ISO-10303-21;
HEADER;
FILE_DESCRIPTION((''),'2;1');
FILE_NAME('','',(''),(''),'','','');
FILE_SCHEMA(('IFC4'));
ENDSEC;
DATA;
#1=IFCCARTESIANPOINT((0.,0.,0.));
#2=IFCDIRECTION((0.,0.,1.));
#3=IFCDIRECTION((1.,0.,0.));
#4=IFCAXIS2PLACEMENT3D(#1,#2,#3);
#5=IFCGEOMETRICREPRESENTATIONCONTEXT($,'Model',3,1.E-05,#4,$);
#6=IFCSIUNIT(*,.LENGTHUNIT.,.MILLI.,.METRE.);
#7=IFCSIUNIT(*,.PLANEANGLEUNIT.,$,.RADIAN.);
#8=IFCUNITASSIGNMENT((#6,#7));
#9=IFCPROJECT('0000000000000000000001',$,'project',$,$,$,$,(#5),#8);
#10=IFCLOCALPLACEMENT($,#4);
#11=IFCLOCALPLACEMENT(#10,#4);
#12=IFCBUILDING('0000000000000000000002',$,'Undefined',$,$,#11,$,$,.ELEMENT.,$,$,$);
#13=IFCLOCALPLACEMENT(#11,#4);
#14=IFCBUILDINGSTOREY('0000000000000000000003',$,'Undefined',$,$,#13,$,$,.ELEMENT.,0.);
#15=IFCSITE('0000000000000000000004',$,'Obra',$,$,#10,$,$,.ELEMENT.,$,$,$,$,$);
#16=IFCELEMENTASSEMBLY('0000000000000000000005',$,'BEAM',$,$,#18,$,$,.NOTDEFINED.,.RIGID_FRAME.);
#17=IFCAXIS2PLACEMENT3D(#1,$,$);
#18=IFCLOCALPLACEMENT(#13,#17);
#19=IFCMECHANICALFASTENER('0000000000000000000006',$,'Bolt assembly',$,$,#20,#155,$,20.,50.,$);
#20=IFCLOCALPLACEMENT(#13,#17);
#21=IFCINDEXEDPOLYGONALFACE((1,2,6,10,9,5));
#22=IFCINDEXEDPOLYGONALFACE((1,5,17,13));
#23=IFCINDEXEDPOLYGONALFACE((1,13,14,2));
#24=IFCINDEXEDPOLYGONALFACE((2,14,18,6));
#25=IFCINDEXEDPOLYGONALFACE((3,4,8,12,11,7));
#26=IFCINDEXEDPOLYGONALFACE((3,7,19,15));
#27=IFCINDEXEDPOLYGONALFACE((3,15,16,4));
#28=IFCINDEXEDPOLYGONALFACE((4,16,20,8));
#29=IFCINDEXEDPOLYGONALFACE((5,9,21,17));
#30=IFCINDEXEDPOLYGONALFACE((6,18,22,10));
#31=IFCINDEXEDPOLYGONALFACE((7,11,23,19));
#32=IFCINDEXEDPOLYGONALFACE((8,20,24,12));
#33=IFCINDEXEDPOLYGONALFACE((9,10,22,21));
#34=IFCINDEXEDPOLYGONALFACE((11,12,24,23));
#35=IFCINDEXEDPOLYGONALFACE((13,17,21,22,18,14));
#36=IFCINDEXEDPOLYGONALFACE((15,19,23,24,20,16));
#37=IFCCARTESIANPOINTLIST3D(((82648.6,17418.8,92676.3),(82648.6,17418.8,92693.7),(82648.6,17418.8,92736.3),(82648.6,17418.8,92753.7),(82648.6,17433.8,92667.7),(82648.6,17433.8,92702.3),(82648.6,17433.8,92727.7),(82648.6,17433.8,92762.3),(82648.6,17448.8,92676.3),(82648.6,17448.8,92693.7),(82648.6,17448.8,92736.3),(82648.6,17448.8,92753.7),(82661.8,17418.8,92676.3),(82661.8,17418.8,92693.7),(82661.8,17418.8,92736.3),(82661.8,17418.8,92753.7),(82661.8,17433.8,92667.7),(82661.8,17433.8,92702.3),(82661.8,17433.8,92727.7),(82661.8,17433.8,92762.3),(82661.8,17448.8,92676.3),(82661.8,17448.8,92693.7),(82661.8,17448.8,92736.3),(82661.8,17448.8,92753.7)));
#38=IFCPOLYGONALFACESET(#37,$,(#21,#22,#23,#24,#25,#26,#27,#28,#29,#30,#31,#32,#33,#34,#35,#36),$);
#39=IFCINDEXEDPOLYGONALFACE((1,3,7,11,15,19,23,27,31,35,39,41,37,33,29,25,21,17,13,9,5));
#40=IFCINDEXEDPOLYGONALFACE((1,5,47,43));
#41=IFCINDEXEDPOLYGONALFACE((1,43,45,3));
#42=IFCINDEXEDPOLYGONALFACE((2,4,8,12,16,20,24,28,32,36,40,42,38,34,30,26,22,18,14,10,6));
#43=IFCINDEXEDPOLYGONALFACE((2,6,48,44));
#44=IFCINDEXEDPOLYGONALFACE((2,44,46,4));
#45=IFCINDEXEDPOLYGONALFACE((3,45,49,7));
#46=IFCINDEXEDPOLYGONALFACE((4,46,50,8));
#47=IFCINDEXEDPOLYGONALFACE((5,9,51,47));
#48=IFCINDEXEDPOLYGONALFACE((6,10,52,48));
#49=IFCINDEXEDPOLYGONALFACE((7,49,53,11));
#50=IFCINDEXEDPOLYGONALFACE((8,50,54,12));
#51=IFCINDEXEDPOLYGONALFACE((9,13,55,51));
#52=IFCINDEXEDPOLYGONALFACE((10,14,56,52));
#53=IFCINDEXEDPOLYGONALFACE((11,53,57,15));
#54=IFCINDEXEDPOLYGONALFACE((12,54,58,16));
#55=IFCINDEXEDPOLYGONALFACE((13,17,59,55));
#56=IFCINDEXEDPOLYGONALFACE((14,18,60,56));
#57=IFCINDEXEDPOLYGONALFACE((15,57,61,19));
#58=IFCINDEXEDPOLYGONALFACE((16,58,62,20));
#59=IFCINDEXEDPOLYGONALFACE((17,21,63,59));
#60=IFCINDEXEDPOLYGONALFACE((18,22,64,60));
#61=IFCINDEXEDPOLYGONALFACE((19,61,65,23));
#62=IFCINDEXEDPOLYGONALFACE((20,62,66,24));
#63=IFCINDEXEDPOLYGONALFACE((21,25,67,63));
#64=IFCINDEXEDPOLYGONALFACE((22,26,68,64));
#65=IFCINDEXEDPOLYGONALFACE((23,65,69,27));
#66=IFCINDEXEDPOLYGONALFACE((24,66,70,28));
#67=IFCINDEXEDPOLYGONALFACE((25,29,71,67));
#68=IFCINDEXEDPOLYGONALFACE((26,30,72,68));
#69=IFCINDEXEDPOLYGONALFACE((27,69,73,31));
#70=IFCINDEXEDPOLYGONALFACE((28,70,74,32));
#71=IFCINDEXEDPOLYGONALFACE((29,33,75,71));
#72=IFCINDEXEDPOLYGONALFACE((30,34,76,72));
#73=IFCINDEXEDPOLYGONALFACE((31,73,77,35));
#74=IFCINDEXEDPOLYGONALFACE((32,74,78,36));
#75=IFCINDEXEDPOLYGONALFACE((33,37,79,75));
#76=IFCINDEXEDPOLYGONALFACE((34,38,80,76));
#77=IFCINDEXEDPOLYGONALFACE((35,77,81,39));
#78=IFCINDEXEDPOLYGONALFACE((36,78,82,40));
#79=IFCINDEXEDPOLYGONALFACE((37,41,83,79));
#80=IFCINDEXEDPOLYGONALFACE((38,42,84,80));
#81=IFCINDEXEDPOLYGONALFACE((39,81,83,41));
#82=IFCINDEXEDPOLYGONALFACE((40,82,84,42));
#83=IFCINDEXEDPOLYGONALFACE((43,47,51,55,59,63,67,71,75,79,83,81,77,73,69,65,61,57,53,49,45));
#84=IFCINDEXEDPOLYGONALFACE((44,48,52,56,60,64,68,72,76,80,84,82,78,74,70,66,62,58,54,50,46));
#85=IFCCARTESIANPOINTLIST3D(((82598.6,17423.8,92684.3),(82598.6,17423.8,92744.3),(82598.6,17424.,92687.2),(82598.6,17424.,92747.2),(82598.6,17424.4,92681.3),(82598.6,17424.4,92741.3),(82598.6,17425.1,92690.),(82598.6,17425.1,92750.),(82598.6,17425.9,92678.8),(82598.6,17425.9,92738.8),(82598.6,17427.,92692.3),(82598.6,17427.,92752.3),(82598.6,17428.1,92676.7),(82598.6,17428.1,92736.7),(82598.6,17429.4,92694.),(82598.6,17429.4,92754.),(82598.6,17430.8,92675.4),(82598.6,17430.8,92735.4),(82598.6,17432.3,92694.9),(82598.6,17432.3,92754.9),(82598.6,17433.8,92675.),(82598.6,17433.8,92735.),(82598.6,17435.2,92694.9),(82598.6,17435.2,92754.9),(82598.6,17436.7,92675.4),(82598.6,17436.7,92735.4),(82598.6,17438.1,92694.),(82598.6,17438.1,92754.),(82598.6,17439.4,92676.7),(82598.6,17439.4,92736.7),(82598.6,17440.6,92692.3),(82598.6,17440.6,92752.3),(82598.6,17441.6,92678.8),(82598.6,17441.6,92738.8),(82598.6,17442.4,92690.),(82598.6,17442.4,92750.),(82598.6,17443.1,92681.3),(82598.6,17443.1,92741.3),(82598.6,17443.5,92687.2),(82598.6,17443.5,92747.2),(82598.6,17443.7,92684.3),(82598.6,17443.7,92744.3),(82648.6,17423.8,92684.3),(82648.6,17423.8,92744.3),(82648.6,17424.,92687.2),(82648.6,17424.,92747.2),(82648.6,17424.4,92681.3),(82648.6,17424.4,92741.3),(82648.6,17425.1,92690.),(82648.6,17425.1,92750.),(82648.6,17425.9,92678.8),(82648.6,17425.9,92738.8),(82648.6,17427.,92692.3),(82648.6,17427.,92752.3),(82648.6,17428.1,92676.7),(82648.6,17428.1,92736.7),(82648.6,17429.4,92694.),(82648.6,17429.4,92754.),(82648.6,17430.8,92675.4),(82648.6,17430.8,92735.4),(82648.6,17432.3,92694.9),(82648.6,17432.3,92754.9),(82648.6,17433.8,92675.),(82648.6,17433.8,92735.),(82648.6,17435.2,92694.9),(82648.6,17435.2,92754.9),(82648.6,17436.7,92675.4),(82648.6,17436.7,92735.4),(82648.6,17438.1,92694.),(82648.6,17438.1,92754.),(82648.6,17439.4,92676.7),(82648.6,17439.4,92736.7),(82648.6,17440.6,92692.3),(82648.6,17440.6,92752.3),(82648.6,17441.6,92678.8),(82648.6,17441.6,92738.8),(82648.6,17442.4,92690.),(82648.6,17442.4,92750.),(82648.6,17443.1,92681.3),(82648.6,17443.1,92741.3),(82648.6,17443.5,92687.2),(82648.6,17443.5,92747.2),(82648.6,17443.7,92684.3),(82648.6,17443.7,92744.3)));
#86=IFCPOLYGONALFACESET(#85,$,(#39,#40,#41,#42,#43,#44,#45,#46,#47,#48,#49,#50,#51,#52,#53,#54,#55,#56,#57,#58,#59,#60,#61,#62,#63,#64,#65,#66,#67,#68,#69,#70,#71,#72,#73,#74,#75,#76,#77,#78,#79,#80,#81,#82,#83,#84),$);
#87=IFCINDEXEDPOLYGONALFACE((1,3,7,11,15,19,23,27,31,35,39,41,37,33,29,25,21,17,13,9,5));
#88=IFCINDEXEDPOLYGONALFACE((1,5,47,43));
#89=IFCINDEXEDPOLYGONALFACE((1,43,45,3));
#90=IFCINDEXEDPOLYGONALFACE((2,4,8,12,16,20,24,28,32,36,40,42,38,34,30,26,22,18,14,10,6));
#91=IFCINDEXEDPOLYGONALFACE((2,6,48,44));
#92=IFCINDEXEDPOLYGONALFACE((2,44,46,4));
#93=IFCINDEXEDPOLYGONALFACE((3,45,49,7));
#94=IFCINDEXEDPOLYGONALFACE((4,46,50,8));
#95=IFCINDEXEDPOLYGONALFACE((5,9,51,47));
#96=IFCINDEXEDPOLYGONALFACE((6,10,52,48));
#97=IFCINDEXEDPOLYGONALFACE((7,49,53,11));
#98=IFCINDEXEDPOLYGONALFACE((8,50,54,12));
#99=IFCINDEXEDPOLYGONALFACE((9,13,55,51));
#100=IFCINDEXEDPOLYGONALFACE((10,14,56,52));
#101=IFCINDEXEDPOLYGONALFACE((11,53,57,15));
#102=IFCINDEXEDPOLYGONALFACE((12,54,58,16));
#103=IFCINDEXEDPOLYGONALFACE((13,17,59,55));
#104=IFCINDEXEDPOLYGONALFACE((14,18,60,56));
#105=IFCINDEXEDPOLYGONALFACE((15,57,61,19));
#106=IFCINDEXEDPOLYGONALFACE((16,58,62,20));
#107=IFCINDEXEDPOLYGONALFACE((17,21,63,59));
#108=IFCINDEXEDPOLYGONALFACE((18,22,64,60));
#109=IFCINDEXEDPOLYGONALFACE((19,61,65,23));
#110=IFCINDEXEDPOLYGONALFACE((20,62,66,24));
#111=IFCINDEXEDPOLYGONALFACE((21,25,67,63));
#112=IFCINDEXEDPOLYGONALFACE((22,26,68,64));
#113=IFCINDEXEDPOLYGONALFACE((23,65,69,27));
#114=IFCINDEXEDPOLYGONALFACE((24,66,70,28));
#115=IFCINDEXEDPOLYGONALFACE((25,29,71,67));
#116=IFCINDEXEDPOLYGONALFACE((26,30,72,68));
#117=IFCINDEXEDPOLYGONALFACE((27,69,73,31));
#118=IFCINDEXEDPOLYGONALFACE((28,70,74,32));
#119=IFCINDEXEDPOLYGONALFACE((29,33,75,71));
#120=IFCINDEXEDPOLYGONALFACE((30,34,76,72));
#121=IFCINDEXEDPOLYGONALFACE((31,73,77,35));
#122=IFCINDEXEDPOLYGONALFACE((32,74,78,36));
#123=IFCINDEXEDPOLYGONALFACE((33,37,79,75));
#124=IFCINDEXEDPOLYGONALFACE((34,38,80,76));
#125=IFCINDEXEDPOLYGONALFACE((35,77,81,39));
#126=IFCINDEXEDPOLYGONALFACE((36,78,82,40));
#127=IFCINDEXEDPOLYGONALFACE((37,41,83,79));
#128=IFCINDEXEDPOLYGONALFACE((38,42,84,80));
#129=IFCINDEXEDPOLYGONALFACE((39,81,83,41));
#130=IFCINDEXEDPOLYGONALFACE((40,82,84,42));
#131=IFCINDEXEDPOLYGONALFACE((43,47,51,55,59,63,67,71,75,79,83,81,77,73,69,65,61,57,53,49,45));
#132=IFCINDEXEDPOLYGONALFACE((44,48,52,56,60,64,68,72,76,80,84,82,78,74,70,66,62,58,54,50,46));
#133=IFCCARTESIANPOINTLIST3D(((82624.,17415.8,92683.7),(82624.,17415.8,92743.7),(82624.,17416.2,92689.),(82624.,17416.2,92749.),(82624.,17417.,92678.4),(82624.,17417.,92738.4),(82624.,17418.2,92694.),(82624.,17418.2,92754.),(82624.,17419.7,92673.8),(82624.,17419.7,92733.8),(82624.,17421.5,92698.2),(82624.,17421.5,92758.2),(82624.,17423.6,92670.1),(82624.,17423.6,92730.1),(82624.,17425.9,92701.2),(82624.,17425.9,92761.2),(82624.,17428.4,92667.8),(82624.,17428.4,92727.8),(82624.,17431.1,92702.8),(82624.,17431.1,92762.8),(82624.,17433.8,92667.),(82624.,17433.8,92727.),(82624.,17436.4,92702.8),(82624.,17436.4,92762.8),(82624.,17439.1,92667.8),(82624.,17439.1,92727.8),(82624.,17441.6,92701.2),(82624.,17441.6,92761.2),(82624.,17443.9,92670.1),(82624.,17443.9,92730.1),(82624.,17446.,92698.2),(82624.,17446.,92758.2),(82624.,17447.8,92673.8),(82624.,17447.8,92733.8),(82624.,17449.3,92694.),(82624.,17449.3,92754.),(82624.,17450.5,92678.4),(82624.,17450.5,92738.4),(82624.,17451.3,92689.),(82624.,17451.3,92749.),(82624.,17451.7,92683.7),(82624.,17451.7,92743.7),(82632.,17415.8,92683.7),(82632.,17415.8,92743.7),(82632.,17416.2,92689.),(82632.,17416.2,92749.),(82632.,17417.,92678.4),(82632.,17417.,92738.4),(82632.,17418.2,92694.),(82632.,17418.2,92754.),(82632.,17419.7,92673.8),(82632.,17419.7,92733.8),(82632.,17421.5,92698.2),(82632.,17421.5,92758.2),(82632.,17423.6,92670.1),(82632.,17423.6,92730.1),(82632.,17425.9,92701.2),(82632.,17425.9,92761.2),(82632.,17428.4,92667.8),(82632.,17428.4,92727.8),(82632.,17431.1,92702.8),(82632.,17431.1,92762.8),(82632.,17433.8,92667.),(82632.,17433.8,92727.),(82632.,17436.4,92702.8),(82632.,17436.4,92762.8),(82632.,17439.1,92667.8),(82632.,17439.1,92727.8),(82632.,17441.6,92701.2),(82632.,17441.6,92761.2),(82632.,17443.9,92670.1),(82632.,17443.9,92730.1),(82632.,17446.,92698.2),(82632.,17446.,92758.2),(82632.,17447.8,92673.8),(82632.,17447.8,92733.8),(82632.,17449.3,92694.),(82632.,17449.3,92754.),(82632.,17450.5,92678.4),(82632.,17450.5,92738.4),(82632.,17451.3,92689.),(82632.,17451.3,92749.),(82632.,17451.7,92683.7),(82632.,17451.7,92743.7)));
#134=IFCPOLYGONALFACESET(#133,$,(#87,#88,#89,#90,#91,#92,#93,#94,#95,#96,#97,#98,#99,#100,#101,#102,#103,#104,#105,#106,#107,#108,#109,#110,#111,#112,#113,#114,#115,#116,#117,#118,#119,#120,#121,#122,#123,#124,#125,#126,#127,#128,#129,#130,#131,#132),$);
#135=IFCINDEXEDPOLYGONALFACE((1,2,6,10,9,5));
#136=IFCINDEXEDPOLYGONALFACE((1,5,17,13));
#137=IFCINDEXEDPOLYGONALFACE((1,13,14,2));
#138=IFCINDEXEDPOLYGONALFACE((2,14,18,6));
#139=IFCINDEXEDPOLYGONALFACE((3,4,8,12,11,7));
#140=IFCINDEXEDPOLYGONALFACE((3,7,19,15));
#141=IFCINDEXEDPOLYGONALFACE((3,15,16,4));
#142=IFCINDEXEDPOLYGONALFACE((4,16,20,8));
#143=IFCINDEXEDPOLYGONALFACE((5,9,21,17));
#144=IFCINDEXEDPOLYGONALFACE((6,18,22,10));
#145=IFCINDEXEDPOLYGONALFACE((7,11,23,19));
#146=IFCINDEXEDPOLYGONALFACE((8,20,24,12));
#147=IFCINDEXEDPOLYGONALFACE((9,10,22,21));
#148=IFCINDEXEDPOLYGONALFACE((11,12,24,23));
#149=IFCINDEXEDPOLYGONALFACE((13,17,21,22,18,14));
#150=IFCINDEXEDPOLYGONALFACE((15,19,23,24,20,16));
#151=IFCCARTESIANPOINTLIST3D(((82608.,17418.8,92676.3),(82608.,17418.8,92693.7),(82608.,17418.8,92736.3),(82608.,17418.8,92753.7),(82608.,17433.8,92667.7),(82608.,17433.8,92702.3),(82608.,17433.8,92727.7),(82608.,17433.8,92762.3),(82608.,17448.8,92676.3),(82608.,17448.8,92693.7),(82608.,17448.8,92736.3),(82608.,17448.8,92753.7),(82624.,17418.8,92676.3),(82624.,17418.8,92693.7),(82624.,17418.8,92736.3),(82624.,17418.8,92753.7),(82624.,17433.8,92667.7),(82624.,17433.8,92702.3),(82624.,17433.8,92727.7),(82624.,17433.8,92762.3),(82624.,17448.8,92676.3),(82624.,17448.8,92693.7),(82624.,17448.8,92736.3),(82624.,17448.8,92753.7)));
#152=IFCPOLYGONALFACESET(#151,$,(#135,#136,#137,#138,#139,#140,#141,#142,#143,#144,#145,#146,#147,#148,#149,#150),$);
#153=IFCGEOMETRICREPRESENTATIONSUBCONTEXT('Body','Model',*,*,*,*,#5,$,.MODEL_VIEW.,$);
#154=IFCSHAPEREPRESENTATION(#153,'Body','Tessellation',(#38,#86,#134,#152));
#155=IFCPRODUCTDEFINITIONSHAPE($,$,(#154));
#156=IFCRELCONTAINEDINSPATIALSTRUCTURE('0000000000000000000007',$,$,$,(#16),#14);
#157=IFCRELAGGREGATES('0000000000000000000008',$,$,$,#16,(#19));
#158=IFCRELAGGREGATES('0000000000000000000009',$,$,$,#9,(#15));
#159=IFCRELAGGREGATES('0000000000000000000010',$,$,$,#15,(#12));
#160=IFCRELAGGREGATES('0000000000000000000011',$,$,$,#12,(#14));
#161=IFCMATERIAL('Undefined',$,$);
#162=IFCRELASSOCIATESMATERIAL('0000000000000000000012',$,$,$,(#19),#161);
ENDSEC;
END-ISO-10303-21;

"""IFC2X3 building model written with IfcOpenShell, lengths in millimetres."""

from ifc_helpers import new_model, si_unit, frame, origin_with_axes, origin_2d_with_axis, place, context, subcontext, project, spatial, polyline, circle, outline, extrude, source, transform, mapped, material, element, aggregate, save


model = new_model("IFC2X3")

# Units and contexts
model_context = context("Model", 3, precision=1e-05, world=origin_with_axes())
body_context = subcontext(model_context, "Body", "Model", "MODEL_VIEW")
ifc_project = project(units=[si_unit("LENGTHUNIT", "METRE", prefix="MILLI"), si_unit("PLANEANGLEUNIT", "RADIAN")], contexts=[model_context])

# Site, building, storey
site_placement = place(None, origin_with_axes())
site = spatial("IfcSite", under=ifc_project, at=site_placement, Name="Obra", CompositionType="ELEMENT")
building_placement = place(site_placement, origin_with_axes())
building = spatial("IfcBuilding", under=site, at=building_placement, Name="Undefined", CompositionType="ELEMENT")
storey_placement = place(building_placement, origin_with_axes())
storey = spatial("IfcBuildingStorey", under=building, at=storey_placement, Name="Undefined", CompositionType="ELEMENT", Elevation=0.0)

# Element assembly, mechanical fastener
assembly_1_placement = place(storey_placement, origin_with_axes())
assembly_1 = element("IfcElementAssembly", 1, at=assembly_1_placement, inside=storey, Name="BEAM", AssemblyPlace="NOTDEFINED", PredefinedType="RIGID_FRAME")
ifc_material_1 = material(Name="Undefined")
shared_shape_1 = source(origin_with_axes(), body_context, "Body", "SweptSolid", [
    extrude(outline(polyline([(17.3, 0.0), (8.7, 15.0), (-8.7, 15.0), (-17.3, 0.0), (-8.7, -15.0), (8.7, -15.0), (17.3, 0.0)])), frame((0.0, -26.5, 0.0), z_axis=(0.0, 1.0, 0.0), x_axis=(1.0, 0.0, 0.0)), (0.0, 0.0, 1.0), 13.2),
    extrude(circle(Radius=10.0, at=origin_2d_with_axis()), frame((0.0, -13.3, 0.0), z_axis=(0.0, 1.0, 0.0), x_axis=(1.0, 0.0, 0.0)), (0.0, 0.0, 1.0), 50.0),
    extrude(circle(Radius=18.0, at=origin_2d_with_axis()), frame((0.0, 3.3, 0.0), z_axis=(0.0, 1.0, 0.0), x_axis=(1.0, 0.0, 0.0)), (0.0, 0.0, 1.0), 8.0),
    extrude(outline(polyline([(17.3, 0.0), (8.7, 15.0), (-8.7, 15.0), (-17.3, 0.0), (-8.7, -15.0), (8.7, -15.0), (17.3, 0.0)])), frame((0.0, 11.3, 0.0), z_axis=(0.0, 1.0, 0.0), x_axis=(1.0, 0.0, 0.0)), (0.0, 0.0, 1.0), 16.0),
])
mechanical_fastener_1_placement = place(assembly_1_placement, frame((82635.3, 17393.8, 92850.0), z_axis=(0.0, 1.0, 0.0), x_axis=(0.0, 0.0, -1.0)))
mechanical_fastener_1 = element("IfcMechanicalFastener", 2, at=mechanical_fastener_1_placement, material=ifc_material_1, Name="Bolt assembly", NominalDiameter=20.0, NominalLength=50.0, context=body_context, shape_type="MappedRepresentation", body=[
    mapped(shared_shape_1, transform((105.0, 0.0, 40.0))),
    mapped(shared_shape_1, transform((165.0, 0.0, 40.0))),
])

aggregate(assembly_1, [mechanical_fastener_1])

save(model, "model.ifc")
